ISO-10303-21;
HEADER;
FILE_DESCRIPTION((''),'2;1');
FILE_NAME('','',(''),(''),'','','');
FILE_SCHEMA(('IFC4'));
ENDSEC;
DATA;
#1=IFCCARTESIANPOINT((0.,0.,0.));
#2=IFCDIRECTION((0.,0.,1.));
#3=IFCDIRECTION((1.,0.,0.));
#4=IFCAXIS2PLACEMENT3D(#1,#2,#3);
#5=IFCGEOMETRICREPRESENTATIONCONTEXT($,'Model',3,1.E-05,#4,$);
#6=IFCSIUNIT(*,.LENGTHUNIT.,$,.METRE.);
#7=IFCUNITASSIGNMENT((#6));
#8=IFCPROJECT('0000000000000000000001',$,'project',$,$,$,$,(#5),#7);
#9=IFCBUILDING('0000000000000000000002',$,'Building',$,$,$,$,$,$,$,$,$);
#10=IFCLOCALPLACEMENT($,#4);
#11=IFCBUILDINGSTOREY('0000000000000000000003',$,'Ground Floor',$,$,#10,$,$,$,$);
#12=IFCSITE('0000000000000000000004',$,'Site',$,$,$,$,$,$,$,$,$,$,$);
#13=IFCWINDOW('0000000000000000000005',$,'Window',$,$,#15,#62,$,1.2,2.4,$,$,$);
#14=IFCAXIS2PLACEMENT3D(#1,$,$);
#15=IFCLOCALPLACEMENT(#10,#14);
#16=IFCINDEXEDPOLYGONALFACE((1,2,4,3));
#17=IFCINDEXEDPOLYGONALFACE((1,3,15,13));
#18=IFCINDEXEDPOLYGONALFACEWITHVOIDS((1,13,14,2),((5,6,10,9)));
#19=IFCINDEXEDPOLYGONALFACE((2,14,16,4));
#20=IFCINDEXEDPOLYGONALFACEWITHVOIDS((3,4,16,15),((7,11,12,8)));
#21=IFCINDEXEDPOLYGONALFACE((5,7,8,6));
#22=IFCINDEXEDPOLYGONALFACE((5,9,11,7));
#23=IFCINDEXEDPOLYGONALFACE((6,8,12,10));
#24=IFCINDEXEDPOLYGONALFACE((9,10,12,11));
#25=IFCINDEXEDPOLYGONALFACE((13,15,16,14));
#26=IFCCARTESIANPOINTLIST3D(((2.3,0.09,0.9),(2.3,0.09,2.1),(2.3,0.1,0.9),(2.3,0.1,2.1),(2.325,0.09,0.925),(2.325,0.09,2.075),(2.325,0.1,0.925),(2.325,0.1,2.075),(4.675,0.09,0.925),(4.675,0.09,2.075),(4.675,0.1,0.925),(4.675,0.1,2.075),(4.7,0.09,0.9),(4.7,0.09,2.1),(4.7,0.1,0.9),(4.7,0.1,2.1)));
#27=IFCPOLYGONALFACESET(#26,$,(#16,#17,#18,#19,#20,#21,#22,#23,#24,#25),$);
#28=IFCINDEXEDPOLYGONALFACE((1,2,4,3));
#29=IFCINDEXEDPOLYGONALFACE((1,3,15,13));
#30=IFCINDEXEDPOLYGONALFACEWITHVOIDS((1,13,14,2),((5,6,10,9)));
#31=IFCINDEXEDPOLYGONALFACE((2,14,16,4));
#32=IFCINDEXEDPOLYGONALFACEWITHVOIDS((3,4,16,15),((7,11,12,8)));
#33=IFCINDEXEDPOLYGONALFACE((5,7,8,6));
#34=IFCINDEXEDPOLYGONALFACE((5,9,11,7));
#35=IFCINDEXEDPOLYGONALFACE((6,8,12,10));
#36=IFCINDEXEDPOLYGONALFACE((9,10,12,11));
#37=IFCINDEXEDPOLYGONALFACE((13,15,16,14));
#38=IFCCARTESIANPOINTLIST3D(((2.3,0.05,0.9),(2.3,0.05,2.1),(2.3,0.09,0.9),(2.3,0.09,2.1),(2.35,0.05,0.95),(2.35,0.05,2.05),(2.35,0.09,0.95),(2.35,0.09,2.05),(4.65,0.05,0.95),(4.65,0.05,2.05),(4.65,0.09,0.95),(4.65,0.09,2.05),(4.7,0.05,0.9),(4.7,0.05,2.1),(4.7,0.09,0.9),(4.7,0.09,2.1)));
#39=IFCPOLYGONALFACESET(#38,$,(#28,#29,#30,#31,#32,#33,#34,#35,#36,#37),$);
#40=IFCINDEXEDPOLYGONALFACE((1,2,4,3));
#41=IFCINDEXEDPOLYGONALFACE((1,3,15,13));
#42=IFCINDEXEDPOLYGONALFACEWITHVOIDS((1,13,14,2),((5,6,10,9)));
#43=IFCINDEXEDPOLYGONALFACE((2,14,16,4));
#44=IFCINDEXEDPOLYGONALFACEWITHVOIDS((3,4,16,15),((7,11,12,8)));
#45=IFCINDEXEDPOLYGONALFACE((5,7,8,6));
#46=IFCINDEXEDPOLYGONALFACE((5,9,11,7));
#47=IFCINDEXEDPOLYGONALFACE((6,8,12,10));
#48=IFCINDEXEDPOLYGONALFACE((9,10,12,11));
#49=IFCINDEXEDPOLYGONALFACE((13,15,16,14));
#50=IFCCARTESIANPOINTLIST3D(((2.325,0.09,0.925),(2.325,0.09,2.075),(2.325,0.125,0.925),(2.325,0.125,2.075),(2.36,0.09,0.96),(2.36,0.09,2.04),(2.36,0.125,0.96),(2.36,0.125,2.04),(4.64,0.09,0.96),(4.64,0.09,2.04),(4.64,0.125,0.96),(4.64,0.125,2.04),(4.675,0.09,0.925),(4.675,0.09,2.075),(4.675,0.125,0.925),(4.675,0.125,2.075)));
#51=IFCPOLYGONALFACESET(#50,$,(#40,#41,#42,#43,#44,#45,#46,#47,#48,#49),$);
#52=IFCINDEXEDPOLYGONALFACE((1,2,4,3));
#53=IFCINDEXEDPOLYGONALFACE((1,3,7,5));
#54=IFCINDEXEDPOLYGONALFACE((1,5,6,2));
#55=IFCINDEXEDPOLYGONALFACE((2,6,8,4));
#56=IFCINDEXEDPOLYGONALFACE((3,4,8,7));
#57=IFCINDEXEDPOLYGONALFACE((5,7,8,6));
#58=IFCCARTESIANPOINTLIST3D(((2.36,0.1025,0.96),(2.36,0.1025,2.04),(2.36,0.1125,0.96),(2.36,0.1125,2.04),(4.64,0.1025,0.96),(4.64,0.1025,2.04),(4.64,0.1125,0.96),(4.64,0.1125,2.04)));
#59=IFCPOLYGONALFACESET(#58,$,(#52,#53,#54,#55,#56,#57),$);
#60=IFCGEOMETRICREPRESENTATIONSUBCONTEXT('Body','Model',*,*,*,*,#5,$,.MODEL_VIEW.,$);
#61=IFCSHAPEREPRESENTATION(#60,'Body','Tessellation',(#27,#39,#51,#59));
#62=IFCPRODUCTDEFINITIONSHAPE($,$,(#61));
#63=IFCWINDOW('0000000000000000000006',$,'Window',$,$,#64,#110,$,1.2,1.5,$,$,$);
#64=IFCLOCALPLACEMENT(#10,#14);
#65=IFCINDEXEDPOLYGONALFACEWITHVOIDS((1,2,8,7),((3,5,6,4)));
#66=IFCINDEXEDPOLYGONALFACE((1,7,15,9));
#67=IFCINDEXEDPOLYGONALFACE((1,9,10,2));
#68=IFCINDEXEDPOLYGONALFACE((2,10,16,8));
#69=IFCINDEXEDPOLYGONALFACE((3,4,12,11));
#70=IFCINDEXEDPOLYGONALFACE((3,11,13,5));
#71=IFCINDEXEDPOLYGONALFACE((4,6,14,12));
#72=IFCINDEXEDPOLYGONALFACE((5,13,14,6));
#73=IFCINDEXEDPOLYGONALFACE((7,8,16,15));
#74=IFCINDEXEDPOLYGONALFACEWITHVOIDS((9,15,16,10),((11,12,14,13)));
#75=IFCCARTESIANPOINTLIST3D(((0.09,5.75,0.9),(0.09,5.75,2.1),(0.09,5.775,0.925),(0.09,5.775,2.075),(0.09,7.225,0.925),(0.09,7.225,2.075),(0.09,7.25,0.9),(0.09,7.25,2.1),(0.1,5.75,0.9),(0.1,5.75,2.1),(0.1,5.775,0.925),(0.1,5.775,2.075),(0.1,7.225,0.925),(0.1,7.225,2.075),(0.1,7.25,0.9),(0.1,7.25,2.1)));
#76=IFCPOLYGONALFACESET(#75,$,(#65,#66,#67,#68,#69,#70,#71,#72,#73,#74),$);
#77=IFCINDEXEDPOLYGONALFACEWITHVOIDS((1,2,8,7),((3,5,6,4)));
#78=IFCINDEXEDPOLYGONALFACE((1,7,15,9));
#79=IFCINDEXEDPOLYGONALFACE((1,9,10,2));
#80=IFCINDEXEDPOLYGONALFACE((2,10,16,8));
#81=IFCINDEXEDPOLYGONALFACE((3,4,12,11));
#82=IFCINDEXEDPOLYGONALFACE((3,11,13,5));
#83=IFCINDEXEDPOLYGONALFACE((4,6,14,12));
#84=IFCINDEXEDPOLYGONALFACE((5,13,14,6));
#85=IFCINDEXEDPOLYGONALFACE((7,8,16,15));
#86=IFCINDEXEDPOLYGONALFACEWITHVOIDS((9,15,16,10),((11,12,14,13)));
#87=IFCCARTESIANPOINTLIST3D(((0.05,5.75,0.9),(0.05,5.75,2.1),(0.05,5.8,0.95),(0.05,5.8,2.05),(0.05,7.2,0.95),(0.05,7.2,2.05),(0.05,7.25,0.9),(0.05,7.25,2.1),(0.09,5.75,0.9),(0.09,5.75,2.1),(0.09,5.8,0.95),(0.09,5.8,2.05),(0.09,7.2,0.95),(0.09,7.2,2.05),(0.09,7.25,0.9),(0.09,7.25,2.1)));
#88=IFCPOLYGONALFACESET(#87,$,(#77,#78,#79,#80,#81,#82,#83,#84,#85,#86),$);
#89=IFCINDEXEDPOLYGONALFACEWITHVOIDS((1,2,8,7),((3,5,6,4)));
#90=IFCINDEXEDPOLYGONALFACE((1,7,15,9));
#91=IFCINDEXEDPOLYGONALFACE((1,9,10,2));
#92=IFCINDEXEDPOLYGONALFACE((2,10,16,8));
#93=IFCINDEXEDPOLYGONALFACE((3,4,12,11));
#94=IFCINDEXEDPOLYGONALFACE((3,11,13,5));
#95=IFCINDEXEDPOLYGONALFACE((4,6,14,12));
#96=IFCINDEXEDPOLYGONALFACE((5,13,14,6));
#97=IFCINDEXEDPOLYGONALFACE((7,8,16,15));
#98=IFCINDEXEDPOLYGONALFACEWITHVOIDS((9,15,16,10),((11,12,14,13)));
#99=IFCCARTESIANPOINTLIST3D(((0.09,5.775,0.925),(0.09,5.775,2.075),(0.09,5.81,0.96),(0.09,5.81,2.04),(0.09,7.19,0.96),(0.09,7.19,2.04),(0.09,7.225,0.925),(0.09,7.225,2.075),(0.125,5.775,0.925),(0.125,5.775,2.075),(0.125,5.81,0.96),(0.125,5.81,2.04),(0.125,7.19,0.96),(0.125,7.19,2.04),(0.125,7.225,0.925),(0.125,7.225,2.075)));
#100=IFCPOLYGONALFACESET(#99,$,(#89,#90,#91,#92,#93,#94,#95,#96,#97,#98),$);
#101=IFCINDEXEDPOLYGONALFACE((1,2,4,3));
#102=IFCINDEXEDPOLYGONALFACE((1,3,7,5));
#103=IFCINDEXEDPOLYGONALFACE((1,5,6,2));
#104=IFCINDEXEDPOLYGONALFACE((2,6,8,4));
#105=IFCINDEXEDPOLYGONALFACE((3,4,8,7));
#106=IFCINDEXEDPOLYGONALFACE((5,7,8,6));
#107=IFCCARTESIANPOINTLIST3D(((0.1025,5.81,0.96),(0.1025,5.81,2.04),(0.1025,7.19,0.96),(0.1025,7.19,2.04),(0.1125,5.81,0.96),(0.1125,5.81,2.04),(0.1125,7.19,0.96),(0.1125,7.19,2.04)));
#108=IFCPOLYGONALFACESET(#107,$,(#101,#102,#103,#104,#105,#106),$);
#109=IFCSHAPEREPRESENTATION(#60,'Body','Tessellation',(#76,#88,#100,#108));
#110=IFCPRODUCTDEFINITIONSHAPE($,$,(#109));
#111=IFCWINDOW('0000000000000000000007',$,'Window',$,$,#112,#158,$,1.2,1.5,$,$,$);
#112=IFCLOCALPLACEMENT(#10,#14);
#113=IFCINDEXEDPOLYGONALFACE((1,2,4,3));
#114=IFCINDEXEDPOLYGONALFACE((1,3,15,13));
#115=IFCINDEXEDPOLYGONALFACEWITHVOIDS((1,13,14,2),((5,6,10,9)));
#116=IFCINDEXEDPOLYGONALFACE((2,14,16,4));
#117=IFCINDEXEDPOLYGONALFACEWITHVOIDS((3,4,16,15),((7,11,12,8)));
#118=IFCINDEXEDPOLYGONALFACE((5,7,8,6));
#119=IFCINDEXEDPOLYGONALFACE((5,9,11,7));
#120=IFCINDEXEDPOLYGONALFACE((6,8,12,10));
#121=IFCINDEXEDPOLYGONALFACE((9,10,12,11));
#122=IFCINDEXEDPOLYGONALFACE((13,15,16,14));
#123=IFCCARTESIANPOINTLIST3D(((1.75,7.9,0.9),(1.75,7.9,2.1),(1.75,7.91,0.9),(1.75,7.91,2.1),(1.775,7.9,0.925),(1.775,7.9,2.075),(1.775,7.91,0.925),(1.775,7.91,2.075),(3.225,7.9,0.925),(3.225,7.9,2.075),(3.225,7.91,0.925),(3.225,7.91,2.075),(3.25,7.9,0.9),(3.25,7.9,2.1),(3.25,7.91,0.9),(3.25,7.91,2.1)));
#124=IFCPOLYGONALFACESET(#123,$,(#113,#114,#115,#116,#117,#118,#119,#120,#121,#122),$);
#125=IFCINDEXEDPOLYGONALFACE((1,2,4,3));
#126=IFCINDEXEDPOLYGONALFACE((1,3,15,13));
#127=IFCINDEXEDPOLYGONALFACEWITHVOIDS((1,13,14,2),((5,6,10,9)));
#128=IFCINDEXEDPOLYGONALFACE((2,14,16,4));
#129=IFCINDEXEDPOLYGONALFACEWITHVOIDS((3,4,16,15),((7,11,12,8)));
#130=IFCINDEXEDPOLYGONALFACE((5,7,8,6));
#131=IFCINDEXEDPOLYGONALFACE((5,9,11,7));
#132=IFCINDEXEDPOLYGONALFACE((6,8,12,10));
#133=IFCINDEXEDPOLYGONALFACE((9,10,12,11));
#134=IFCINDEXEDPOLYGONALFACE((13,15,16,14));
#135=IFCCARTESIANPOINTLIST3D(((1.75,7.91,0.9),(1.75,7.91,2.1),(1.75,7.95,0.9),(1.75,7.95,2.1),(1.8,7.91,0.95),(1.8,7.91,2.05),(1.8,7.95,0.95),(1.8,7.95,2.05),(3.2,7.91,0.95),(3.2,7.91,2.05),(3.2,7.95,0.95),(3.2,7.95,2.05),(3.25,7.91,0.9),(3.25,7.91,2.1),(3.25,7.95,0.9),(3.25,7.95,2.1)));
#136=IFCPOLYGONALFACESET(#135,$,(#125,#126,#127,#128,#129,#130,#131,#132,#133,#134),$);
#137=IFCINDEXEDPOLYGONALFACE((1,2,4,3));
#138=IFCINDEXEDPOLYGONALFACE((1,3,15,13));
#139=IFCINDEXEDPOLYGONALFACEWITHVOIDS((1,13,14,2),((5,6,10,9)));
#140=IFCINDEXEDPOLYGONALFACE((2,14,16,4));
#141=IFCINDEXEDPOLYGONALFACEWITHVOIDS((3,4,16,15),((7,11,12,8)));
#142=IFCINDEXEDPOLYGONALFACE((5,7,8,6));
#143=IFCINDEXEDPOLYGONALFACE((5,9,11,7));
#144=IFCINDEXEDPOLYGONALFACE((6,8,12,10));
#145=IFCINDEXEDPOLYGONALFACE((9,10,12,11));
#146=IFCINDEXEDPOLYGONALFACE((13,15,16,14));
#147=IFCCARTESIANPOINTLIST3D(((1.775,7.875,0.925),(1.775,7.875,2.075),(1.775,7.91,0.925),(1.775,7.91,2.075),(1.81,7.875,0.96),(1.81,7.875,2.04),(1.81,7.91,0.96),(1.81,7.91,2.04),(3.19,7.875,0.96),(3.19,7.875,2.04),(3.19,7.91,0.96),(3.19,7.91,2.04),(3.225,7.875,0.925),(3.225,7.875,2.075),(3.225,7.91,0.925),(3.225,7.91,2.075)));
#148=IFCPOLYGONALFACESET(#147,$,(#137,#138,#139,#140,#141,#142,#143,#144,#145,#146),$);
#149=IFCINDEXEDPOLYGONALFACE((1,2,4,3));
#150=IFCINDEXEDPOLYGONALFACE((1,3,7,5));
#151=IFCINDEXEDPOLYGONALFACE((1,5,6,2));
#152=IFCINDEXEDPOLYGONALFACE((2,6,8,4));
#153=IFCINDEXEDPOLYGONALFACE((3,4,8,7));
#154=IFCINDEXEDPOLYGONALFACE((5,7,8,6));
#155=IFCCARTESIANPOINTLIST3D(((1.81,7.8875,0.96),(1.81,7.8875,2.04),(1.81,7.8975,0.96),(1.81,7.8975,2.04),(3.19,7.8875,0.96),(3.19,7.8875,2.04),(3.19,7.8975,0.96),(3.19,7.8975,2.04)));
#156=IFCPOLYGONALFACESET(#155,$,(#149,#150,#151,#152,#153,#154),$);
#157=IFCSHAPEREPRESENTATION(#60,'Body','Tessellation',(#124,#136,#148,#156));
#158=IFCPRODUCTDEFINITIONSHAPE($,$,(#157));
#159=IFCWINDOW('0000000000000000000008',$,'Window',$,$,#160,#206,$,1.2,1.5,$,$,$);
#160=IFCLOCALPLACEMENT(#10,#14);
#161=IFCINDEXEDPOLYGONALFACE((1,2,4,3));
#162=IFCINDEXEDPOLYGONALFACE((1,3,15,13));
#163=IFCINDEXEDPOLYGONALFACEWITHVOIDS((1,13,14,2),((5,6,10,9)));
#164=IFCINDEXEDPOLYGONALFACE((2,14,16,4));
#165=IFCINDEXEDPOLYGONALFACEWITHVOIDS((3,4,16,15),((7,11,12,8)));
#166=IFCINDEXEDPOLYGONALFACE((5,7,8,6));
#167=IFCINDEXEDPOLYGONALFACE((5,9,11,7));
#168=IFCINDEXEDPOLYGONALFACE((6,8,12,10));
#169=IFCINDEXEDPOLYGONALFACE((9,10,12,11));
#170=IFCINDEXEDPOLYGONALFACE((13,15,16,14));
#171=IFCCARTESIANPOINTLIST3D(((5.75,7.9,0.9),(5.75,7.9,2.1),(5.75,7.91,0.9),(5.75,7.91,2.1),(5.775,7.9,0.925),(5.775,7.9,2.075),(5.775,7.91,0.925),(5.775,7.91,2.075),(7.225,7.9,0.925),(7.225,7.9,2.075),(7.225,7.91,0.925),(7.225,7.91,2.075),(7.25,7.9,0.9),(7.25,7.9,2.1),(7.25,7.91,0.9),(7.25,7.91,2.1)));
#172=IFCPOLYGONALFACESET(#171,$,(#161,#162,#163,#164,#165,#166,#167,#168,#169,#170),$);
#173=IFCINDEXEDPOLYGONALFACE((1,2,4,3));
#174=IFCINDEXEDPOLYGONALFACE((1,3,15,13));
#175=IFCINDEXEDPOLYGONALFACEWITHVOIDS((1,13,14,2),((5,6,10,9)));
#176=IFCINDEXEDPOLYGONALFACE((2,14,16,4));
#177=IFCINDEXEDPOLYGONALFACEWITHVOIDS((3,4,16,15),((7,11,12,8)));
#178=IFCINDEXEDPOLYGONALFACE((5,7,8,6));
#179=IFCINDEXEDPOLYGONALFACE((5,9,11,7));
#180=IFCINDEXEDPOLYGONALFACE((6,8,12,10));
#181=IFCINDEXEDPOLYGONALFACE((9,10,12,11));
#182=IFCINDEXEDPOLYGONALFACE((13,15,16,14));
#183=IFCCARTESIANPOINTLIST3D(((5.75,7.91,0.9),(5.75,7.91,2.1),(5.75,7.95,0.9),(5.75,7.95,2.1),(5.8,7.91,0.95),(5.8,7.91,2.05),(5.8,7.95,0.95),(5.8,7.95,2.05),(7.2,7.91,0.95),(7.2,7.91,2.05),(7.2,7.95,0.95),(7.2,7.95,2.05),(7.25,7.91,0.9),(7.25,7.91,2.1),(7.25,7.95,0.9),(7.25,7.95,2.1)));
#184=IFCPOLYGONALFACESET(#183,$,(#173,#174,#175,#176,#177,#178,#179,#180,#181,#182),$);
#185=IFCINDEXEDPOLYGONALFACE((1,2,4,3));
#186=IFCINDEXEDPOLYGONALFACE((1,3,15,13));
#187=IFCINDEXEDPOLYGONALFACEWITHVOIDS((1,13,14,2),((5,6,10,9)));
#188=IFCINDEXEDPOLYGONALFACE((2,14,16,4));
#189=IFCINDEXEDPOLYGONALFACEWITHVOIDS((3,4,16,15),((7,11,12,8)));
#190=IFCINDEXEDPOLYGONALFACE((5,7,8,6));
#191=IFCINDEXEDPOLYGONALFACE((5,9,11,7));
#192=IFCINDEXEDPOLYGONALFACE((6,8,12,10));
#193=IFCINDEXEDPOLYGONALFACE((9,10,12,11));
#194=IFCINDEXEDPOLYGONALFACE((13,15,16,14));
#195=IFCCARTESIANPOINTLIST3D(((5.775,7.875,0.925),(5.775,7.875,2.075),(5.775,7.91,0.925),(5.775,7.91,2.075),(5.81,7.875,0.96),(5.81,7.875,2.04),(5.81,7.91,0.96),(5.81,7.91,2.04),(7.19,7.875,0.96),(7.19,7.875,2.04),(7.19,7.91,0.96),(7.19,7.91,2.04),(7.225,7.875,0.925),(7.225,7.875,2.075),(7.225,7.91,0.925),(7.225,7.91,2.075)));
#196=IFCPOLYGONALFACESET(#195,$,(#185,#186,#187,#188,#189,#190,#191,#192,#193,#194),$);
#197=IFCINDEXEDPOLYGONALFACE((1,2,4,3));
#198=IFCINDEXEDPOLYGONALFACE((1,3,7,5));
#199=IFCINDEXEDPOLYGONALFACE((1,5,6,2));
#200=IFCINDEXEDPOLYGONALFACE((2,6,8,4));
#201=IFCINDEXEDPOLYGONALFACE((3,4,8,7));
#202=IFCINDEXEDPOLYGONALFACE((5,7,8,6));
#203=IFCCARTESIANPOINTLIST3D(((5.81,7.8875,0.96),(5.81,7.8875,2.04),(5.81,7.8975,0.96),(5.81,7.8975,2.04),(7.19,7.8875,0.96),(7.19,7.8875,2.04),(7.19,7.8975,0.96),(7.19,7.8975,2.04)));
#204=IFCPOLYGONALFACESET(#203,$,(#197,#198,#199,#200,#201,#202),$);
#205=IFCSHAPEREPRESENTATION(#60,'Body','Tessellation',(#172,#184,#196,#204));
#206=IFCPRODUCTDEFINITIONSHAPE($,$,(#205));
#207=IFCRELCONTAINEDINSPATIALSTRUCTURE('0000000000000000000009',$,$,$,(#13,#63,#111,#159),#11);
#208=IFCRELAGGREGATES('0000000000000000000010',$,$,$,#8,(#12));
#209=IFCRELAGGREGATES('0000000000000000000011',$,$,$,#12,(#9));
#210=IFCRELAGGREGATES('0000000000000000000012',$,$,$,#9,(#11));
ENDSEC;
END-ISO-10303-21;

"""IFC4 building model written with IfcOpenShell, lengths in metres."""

from ifc_helpers import new_model, si_unit, frame, origin_with_axes, place, context, subcontext, project, spatial, line, indexed_curve, outline, extrude, element, save


model = new_model("IFC4")

# Units and contexts
model_context = context("Model", 3, precision=1e-05, world=origin_with_axes())
body_context = subcontext(model_context, "Body", "Model", "MODEL_VIEW")
ifc_project = project(units=[si_unit("LENGTHUNIT", "METRE")], contexts=[model_context])

# Site, building, storey
site = spatial("IfcSite", under=ifc_project, Name="Site")
building = spatial("IfcBuilding", under=site, Name="Building")
storey_placement = place(None, origin_with_axes())
storey = spatial("IfcBuildingStorey", under=building, at=storey_placement, Name="Ground Floor")

# Windows
window_1_placement = place(storey_placement, frame((2.3, 0.0, 0.9), z_axis=(0.0, 0.0, 1.0), x_axis=(1.0, 0.0, 0.0)))
element("IfcWindow", 1, at=window_1_placement, inside=storey, Name="Window", OverallHeight=1.2, OverallWidth=2.4, context=body_context, shape_type="SweptSolid", body=[
    extrude(outline(indexed_curve([(0.0, 0.0), (2.4, 0.0), (2.4, 1.2), (0.0, 1.2)], segments=[line(1, 2, 3, 4, 1)]), holes=[indexed_curve([(0.025, 0.025), (2.375, 0.025), (2.375, 1.175), (0.025, 1.175)], segments=[line(1, 2, 3, 4, 1)])]), frame((0.0, 0.09, 0.0), z_axis=(0.0, -1.0, 0.0), x_axis=(1.0, 0.0, 0.0)), (0.0, 0.0, -1.0), 0.01),
    extrude(outline(indexed_curve([(0.0, 0.0), (2.4, 0.0), (2.4, 1.2), (0.0, 1.2)], segments=[line(1, 2, 3, 4, 1)]), holes=[indexed_curve([(0.05, 0.05), (2.35, 0.05), (2.35, 1.15), (0.05, 1.15)], segments=[line(1, 2, 3, 4, 1)])]), frame((0.0, 0.05, 0.0), z_axis=(0.0, -1.0, 0.0), x_axis=(1.0, 0.0, 0.0)), (0.0, 0.0, -1.0), 0.04),
    extrude(outline(indexed_curve([(0.0, 0.0), (2.35, 0.0), (2.35, 1.15), (0.0, 1.15)], segments=[line(1, 2, 3, 4, 1)]), holes=[indexed_curve([(0.035, 0.035), (2.315, 0.035), (2.315, 1.115), (0.035, 1.115)], segments=[line(1, 2, 3, 4, 1)])]), frame((0.025, 0.09, 0.025), z_axis=(0.0, -1.0, 0.0), x_axis=(1.0, 0.0, 0.0)), (0.0, 0.0, -1.0), 0.035),
    extrude(outline(indexed_curve([(0.035, 0.035), (2.315, 0.035), (2.315, 1.115), (0.035, 1.115)], segments=[line(1, 2, 3, 4, 1)])), frame((0.025, 0.1025, 0.025), z_axis=(0.0, -1.0, 0.0), x_axis=(1.0, 0.0, 0.0)), (0.0, 0.0, -1.0), 0.01),
])
for number, where, z_axis, x_axis, name in (
    (2, (0.0, 7.25, 0.9), (0.0, 0.0, 1.0), (0.0, -1.0, 0.0), "Window"),
    (3, (3.25, 8.0, 0.9), (0.0, 0.0, 1.0), (-1.0, 0.0, 0.0), "Window"),
    (4, (7.25, 8.0, 0.9), (0.0, 0.0, 1.0), (-1.0, 0.0, 0.0), "Window"),
):
    element("IfcWindow", number, at=place(storey_placement, frame(where, z_axis=z_axis, x_axis=x_axis)), inside=storey, Name=name, OverallHeight=1.2, OverallWidth=1.5, context=body_context, shape_type="SweptSolid", body=[
        extrude(outline(indexed_curve([(0.0, 0.0), (1.5, 0.0), (1.5, 1.2), (0.0, 1.2)], segments=[line(1, 2, 3, 4, 1)]), holes=[indexed_curve([(0.025, 0.025), (1.475, 0.025), (1.475, 1.175), (0.025, 1.175)], segments=[line(1, 2, 3, 4, 1)])]), frame((0.0, 0.09, 0.0), z_axis=(0.0, -1.0, 0.0), x_axis=(1.0, 0.0, 0.0)), (0.0, 0.0, -1.0), 0.01),
        extrude(outline(indexed_curve([(0.0, 0.0), (1.5, 0.0), (1.5, 1.2), (0.0, 1.2)], segments=[line(1, 2, 3, 4, 1)]), holes=[indexed_curve([(0.05, 0.05), (1.45, 0.05), (1.45, 1.15), (0.05, 1.15)], segments=[line(1, 2, 3, 4, 1)])]), frame((0.0, 0.05, 0.0), z_axis=(0.0, -1.0, 0.0), x_axis=(1.0, 0.0, 0.0)), (0.0, 0.0, -1.0), 0.04),
        extrude(outline(indexed_curve([(0.0, 0.0), (1.45, 0.0), (1.45, 1.15), (0.0, 1.15)], segments=[line(1, 2, 3, 4, 1)]), holes=[indexed_curve([(0.035, 0.035), (1.415, 0.035), (1.415, 1.115), (0.035, 1.115)], segments=[line(1, 2, 3, 4, 1)])]), frame((0.025, 0.09, 0.025), z_axis=(0.0, -1.0, 0.0), x_axis=(1.0, 0.0, 0.0)), (0.0, 0.0, -1.0), 0.035),
        extrude(outline(indexed_curve([(0.035, 0.035), (1.415, 0.035), (1.415, 1.115), (0.035, 1.115)], segments=[line(1, 2, 3, 4, 1)])), frame((0.025, 0.1025, 0.025), z_axis=(0.0, -1.0, 0.0), x_axis=(1.0, 0.0, 0.0)), (0.0, 0.0, -1.0), 0.01),
    ])

save(model, "model.ifc")
